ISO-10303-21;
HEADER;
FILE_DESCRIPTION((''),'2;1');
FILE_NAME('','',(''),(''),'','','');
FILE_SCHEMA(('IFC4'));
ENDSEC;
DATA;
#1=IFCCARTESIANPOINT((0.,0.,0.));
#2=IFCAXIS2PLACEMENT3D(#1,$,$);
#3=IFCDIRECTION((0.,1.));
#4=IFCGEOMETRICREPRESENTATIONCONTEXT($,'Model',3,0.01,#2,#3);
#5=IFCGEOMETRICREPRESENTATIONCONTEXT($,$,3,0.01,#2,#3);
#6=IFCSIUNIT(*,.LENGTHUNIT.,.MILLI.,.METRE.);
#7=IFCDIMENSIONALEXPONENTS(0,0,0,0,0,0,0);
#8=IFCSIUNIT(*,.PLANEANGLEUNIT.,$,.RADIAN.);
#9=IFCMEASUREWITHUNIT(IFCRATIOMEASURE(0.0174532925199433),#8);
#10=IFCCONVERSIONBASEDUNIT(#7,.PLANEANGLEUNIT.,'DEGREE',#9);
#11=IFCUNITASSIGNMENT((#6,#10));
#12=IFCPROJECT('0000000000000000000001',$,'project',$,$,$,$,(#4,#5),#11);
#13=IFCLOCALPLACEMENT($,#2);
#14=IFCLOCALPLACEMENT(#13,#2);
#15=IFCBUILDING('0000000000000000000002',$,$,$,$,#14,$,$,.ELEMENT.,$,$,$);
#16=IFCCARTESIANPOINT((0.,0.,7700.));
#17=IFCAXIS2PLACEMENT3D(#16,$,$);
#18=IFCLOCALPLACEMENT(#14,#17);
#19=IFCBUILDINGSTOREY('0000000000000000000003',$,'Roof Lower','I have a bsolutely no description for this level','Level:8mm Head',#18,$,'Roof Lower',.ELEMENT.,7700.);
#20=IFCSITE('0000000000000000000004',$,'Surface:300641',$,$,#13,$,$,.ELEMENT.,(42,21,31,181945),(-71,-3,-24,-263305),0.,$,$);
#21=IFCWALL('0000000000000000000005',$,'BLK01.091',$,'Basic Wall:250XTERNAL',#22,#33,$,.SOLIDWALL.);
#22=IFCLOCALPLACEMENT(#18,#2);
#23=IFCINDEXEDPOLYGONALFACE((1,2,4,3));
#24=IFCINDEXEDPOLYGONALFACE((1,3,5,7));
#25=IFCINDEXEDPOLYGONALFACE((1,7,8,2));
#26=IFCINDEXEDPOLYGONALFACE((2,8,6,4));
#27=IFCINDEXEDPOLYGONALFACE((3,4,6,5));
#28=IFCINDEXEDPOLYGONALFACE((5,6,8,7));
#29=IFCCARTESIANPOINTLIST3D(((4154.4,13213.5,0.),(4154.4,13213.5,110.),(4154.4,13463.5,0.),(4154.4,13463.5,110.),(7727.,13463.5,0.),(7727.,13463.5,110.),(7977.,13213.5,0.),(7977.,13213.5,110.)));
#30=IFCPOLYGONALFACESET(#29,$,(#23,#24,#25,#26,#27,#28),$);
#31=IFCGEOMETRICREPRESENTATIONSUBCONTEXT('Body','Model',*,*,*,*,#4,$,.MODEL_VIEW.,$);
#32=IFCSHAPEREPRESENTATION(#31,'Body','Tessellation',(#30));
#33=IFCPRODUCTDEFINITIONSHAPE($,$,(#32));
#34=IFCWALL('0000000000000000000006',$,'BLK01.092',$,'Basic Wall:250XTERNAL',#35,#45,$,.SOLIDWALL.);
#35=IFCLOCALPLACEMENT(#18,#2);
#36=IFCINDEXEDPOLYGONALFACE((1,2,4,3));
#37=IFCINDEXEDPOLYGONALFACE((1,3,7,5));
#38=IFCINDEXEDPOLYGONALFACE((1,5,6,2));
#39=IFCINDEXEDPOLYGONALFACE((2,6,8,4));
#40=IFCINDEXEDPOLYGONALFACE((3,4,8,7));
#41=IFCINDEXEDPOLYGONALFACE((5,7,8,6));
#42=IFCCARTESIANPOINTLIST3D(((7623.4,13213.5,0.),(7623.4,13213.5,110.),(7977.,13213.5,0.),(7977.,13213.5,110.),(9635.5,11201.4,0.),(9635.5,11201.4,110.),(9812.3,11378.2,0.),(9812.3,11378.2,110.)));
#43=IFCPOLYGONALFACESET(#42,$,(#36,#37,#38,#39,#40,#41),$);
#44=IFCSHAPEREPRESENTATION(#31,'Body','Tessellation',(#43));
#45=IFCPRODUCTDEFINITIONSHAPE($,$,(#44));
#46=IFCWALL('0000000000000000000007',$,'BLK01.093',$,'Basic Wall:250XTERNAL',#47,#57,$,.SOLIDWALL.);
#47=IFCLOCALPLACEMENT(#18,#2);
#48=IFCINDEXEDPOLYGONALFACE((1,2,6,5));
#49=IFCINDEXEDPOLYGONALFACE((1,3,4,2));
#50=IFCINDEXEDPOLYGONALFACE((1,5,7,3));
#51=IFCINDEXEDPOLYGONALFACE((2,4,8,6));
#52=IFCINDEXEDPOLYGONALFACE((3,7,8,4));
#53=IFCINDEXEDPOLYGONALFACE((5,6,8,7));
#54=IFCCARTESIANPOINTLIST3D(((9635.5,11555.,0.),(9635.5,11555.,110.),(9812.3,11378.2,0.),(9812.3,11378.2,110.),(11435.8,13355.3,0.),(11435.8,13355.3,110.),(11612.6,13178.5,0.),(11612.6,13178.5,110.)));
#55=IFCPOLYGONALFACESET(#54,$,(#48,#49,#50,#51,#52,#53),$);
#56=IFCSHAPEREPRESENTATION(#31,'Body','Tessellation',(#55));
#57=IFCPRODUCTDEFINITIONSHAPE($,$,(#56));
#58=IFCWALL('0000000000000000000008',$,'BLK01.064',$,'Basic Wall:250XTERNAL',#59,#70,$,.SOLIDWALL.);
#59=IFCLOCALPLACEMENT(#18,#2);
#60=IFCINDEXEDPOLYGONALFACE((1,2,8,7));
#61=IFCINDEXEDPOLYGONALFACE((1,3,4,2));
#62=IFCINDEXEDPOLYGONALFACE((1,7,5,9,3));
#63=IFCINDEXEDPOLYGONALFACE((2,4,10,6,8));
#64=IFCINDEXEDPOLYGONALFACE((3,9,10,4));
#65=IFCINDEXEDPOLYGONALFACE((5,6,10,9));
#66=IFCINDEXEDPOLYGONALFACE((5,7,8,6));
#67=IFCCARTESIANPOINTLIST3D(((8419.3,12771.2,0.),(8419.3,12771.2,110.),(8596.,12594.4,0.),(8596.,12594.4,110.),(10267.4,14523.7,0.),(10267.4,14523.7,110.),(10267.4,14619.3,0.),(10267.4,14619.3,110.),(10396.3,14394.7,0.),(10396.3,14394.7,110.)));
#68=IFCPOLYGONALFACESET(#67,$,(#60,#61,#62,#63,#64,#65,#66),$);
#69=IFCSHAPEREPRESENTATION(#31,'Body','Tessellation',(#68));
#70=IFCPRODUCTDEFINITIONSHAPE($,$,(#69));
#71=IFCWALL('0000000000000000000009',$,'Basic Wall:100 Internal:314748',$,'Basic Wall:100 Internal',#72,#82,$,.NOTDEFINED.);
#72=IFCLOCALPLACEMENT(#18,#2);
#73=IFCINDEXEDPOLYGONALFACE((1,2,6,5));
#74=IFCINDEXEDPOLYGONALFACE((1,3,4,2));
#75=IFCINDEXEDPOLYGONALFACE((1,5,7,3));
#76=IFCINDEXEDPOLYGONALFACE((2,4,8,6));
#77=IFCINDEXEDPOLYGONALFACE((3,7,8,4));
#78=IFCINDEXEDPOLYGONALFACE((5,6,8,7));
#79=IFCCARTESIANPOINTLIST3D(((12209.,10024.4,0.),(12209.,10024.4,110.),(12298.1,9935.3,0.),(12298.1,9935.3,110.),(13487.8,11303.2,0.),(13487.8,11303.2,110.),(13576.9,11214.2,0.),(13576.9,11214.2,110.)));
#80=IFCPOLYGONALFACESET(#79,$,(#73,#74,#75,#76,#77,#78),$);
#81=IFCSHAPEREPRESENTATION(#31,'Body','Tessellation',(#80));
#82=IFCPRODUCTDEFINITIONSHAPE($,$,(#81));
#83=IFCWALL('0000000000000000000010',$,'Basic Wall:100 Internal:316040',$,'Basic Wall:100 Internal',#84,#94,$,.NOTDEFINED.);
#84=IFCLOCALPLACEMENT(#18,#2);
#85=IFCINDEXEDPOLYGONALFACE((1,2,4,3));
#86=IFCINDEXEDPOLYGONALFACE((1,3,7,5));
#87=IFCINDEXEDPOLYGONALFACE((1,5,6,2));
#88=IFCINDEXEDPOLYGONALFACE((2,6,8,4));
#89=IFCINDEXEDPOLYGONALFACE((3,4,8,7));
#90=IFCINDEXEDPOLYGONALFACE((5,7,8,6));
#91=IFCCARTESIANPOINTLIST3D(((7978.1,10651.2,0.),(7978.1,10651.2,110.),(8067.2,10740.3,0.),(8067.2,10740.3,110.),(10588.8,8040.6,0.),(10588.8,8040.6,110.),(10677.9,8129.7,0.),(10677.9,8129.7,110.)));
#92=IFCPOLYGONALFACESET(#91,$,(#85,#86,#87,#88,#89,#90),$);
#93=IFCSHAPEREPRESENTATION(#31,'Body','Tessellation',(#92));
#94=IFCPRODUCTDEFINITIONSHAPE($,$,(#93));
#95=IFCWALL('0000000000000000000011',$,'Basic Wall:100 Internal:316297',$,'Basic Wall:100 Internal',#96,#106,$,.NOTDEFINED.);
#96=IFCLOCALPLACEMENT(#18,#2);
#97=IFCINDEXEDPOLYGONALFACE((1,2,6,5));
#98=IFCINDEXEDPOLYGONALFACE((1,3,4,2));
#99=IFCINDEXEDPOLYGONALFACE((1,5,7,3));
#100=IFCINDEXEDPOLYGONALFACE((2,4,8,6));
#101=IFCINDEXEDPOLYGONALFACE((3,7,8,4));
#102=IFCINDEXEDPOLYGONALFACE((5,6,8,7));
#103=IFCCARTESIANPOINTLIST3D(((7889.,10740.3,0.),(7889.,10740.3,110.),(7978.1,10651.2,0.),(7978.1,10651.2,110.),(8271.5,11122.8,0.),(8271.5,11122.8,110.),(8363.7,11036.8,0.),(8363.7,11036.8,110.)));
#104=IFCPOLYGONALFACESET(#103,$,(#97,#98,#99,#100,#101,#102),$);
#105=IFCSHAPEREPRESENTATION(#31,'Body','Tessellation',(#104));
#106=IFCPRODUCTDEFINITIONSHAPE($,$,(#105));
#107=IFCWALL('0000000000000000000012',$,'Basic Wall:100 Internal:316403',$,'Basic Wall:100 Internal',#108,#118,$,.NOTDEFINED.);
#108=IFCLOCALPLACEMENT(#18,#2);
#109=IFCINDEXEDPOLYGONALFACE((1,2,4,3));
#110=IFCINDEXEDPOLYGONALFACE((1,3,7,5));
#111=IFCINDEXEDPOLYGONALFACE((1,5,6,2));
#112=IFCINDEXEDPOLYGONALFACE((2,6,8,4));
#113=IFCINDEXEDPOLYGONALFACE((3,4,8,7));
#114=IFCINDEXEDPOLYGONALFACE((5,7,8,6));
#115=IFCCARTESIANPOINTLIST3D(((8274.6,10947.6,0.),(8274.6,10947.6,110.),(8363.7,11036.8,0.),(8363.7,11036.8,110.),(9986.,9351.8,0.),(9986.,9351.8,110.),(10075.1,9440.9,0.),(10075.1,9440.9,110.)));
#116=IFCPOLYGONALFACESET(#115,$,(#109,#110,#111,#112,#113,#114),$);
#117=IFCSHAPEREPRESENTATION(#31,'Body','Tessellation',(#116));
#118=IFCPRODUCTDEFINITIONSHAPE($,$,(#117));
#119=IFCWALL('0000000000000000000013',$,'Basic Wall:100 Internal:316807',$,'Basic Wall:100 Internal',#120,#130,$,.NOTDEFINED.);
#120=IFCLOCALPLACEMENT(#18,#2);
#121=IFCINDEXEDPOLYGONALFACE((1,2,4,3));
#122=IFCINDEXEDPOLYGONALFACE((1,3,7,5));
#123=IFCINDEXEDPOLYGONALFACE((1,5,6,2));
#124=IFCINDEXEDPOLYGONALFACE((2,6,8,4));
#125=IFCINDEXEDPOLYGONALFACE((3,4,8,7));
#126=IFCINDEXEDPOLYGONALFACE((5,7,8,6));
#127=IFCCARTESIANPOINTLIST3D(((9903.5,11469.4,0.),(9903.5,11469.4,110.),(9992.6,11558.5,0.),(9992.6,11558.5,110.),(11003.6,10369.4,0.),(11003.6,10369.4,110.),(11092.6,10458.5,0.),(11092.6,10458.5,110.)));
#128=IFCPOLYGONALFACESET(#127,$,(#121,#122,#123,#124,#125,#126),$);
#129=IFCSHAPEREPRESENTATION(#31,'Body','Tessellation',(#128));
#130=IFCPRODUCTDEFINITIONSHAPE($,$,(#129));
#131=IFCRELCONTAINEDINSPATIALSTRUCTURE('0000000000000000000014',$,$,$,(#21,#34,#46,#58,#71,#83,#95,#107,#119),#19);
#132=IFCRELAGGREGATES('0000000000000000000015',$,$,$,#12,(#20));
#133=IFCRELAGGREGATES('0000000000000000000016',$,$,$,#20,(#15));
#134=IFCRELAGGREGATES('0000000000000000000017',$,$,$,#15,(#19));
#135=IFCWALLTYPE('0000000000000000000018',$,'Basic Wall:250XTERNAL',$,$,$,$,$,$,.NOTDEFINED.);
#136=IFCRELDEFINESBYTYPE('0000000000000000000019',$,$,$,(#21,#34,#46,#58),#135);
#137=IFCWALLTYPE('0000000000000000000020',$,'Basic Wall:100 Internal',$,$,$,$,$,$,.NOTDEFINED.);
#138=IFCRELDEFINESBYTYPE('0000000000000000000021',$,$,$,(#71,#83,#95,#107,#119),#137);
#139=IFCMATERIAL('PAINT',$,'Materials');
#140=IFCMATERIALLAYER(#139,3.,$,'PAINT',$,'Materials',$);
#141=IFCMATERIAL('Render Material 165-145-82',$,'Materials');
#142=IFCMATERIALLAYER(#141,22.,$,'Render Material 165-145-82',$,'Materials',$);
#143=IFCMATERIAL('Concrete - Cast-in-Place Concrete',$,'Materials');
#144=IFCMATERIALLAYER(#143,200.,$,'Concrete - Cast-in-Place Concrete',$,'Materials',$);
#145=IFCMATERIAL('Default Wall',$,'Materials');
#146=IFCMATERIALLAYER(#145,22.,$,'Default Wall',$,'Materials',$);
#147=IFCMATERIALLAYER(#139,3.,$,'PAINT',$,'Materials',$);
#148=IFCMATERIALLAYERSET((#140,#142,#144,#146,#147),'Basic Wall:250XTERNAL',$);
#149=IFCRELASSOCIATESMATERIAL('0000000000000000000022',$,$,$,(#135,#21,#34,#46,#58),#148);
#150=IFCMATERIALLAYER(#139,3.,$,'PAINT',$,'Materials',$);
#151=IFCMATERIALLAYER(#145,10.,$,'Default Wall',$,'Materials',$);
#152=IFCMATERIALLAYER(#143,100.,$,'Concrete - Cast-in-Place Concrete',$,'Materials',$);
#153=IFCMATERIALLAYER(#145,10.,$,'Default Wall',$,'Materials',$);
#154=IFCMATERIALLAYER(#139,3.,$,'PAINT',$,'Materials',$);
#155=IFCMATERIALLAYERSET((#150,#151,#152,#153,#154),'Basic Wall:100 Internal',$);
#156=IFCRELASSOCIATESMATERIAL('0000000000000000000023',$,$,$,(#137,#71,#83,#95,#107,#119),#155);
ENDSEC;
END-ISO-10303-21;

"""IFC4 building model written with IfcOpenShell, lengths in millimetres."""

from ifc_helpers import new_model, entity, si_unit, converted_unit, direction, frame, frame_2d, origin, place, context, subcontext, project, spatial, polyline, rectangle, outline, extrude, clip, halfspace, bounded_halfspace, material, layer, layer_set, layer_usage, type_object, element, save


model = new_model("IFC4")

# Units and contexts
model_context = context("Model", 3, precision=0.01, world=origin(), true_north=direction((0.0, 1.0)))
context_of_model = context(None, 3, precision=0.01, world=origin(), true_north=direction((0.0, 1.0)))
body_context = subcontext(model_context, "Body", "Model", "MODEL_VIEW")
ifc_project = project(units=[si_unit("LENGTHUNIT", "METRE", prefix="MILLI"), converted_unit("PLANEANGLEUNIT", "DEGREE", entity("IfcRatioMeasure", 0.0174532925199433), si_unit("PLANEANGLEUNIT", "RADIAN"), dimensions=[0, 0, 0, 0, 0, 0, 0])], contexts=[model_context, context_of_model])

# Site, building, storey
site_placement = place(None, origin())
site = spatial("IfcSite", under=ifc_project, at=site_placement, Name="Surface:300641", CompositionType="ELEMENT", RefLatitude=(42, 21, 31, 181945), RefLongitude=(-71, -3, -24, -263305), RefElevation=0.0)
building_placement = place(site_placement, origin())
building = spatial("IfcBuilding", under=site, at=building_placement, CompositionType="ELEMENT")
storey_placement = place(building_placement, frame((0.0, 0.0, 7700.0)))
storey = spatial("IfcBuildingStorey", under=building, at=storey_placement, Name="Roof Lower", Description="I have a bsolutely no description for this level", ObjectType="Level:8mm Head", LongName="Roof Lower", CompositionType="ELEMENT", Elevation=7700.0)

# Shared definitions
ifc_material_1 = material(Name="Concrete - Cast-in-Place Concrete", Category="Materials")

# Walls
ifc_material_2 = material(Name="PAINT", Category="Materials")
ifc_layer_1 = layer(ifc_material_2, 3.0, Name="PAINT", Category="Materials")
ifc_material_3 = material(Name="Render Material 165-145-82", Category="Materials")
ifc_layer_2 = layer(ifc_material_3, 22.0, Name="Render Material 165-145-82", Category="Materials")
ifc_layer_3 = layer(ifc_material_1, 200.0, Name="Concrete - Cast-in-Place Concrete", Category="Materials")
ifc_material_4 = material(Name="Default Wall", Category="Materials")
ifc_layer_4 = layer(ifc_material_4, 22.0, Name="Default Wall", Category="Materials")
ifc_layer_5 = layer(ifc_material_2, 3.0, Name="PAINT", Category="Materials")
ifc_layer_set_1 = layer_set([ifc_layer_1, ifc_layer_2, ifc_layer_3, ifc_layer_4, ifc_layer_5], Name="Basic Wall:250XTERNAL")
ifc_layer_usage_1 = layer_usage(ifc_layer_set_1, "AXIS2", "NEGATIVE", 125.0)
wall_type_1 = type_object("IfcWallType", Name="Basic Wall:250XTERNAL", PredefinedType="NOTDEFINED", material=ifc_layer_set_1)
wall_1_placement = place(storey_placement, frame((4154.4, 13338.5, 0.0)))
element("IfcWall", 1, at=wall_1_placement, inside=storey, type_object=wall_type_1, material=ifc_layer_usage_1, Name="BLK01.091", ObjectType="Basic Wall:250XTERNAL", PredefinedType="SOLIDWALL", context=body_context, shape_type="Clipping", body=[
    clip(clip(extrude(outline(polyline([(0.0, -125.0), (3469.0, -125.0), (3822.5, -125.0), (3572.5, 125.0), (0.0, 125.0), (0.0, -125.0)])), origin(), (0.0, 0.0, 1.0), 110.0), bounded_halfspace(frame((0.0, -125.0, 110.0), z_axis=(0.0, 0.0, -1.0), x_axis=(1.0, 0.0, 0.0)), True, frame((0.0, -125.0, 110.0)), polyline([(0.0, 0.0), (3469.0, 0.0), (3822.5, 0.0), (3572.5, 250.0), (0.0, 250.0), (0.0, 0.0)]))), halfspace(frame((0.0, 0.0, -3500.0)), True)),
])
ifc_layer_usage_2 = layer_usage(ifc_layer_set_1, "AXIS2", "NEGATIVE", 125.0)
wall_2_placement = place(storey_placement, frame((7711.8, 13301.9, 0.0), z_axis=(0.0, 0.0, 1.0), x_axis=(0.707107, -0.707107, 0.0)))
element("IfcWall", 2, at=wall_2_placement, inside=storey, type_object=wall_type_1, material=ifc_layer_usage_2, Name="BLK01.092", ObjectType="Basic Wall:250XTERNAL", PredefinedType="SOLIDWALL", context=body_context, shape_type="Clipping", body=[
    clip(clip(extrude(outline(polyline([(2845.5, -125.0), (2845.5, 0.0), (2845.5, 125.0), (2595.5, 125.0), (1125.5, 125.0), (875.5, 125.0), (250.0, 125.0), (0.0, -125.0), (2845.5, -125.0)])), origin(), (0.0, 0.0, 1.0), 110.0), bounded_halfspace(frame((0.0, -125.0, 110.0), z_axis=(0.0, 0.0, -1.0), x_axis=(0.707107, 0.707107, 0.0)), True, frame((0.0, -125.0, 110.0)), polyline([(0.0, 0.0), (2845.5, 0.0), (2845.5, 125.0), (2845.5, 250.0), (2595.5, 250.0), (1125.5, 250.0), (875.5, 250.0), (250.0, 250.0), (0.0, 0.0)]))), halfspace(frame((0.0, 0.0, -3500.0)), True)),
])
ifc_layer_usage_3 = layer_usage(ifc_layer_set_1, "AXIS2", "NEGATIVE", 125.0)
wall_3_placement = place(storey_placement, frame((9723.9, 11466.6, 0.0), z_axis=(0.0, 0.0, 1.0), x_axis=(0.707107, 0.707107, 0.0)))
element("IfcWall", 3, at=wall_3_placement, inside=storey, type_object=wall_type_1, material=ifc_layer_usage_3, Name="BLK01.093", ObjectType="Basic Wall:250XTERNAL", PredefinedType="SOLIDWALL", context=body_context, shape_type="Clipping", body=[
    clip(clip(extrude(rectangle(XDim=2546.0, YDim=250.0, at=frame_2d((1273.0, 0.0), x_axis=(-1.0, 0.0))), origin(), (0.0, 0.0, 1.0), 110.0), bounded_halfspace(frame((0.0, -125.0, 110.0), z_axis=(0.0, 0.0, -1.0), x_axis=(0.707107, -0.707107, 0.0)), True, frame((0.0, -125.0, 110.0)), polyline([(0.0, 0.0), (129.0, 0.0), (255.0, 0.0), (2546.0, 0.0), (2546.0, 250.0), (0.0, 250.0), (0.0, 0.0)]))), halfspace(frame((0.0, 0.0, -3500.0)), True)),
])
ifc_layer_usage_4 = layer_usage(ifc_layer_set_1, "AXIS2", "POSITIVE", -125.0)
wall_4_placement = place(storey_placement, frame((8507.6, 12682.8, 0.0), z_axis=(0.0, 0.0, 1.0), x_axis=(0.707107, 0.707107, 0.0)))
element("IfcWall", 4, at=wall_4_placement, inside=storey, type_object=wall_type_1, material=ifc_layer_usage_4, Name="BLK01.064", ObjectType="Basic Wall:250XTERNAL", PredefinedType="SOLIDWALL", context=body_context, shape_type="Clipping", body=[
    clip(clip(extrude(outline(polyline([(2546.0, -125.0), (2546.0, 57.4), (2613.6, 125.0), (0.0, 125.0), (0.0, -125.0), (2546.0, -125.0)])), origin(), (0.0, 0.0, 1.0), 110.0), bounded_halfspace(frame((0.0, -125.0, 110.0), z_axis=(0.0, 0.0, -1.0), x_axis=(0.707107, -0.707107, 0.0)), True, frame((0.0, -125.0, 110.0)), polyline([(0.0, 0.0), (2546.0, 0.0), (2546.0, 182.4), (2613.6, 250.0), (0.0, 250.0), (0.0, 0.0)]))), halfspace(frame((0.0, 0.0, -3500.0)), True)),
])
ifc_layer_6 = layer(ifc_material_2, 3.0, Name="PAINT", Category="Materials")
ifc_layer_7 = layer(ifc_material_4, 10.0, Name="Default Wall", Category="Materials")
ifc_layer_8 = layer(ifc_material_1, 100.0, Name="Concrete - Cast-in-Place Concrete", Category="Materials")
ifc_layer_9 = layer(ifc_material_4, 10.0, Name="Default Wall", Category="Materials")
ifc_layer_10 = layer(ifc_material_2, 3.0, Name="PAINT", Category="Materials")
ifc_layer_set_2 = layer_set([ifc_layer_6, ifc_layer_7, ifc_layer_8, ifc_layer_9, ifc_layer_10], Name="Basic Wall:100 Internal")
ifc_layer_usage_5 = layer_usage(ifc_layer_set_2, "AXIS2", "NEGATIVE", 63.0)
wall_type_2 = type_object("IfcWallType", Name="Basic Wall:100 Internal", PredefinedType="NOTDEFINED", material=ifc_layer_set_2)
wall_5_placement = place(storey_placement, frame((13532.4, 11258.7, 0.0), z_axis=(0.0, 0.0, 1.0), x_axis=(-0.707107, -0.707107, 0.0)))
element("IfcWall", 5, at=wall_5_placement, inside=storey, type_object=wall_type_2, material=ifc_layer_usage_5, Name="Basic Wall:100 Internal:314748", ObjectType="Basic Wall:100 Internal", PredefinedType="NOTDEFINED", context=body_context, shape_type="Clipping", body=[
    clip(clip(extrude(rectangle(XDim=1808.6, YDim=126.0, at=frame_2d((904.3, 0.0), x_axis=(-1.0, 0.0))), origin(), (0.0, 0.0, 1.0), 110.0), bounded_halfspace(frame((0.0, -63.0, 110.0), z_axis=(0.0, 0.0, -1.0), x_axis=(-0.707107, 0.707107, 0.0)), True, frame((0.0, -63.0, 110.0)), polyline([(0.0, 0.0), (1808.6, 0.0), (1808.6, 126.0), (0.0, 126.0), (0.0, 0.0)]))), halfspace(frame((0.0, 0.0, -3500.0)), True)),
])
ifc_layer_usage_6 = layer_usage(ifc_layer_set_2, "AXIS2", "POSITIVE", -63.0)
wall_6_placement = place(storey_placement, frame((8022.7, 10695.7, 0.0), z_axis=(0.0, 0.0, 1.0), x_axis=(0.707107, -0.707107, 0.0)))
element("IfcWall", 6, at=wall_6_placement, inside=storey, type_object=wall_type_2, material=ifc_layer_usage_6, Name="Basic Wall:100 Internal:316040", ObjectType="Basic Wall:100 Internal", PredefinedType="NOTDEFINED", context=body_context, shape_type="Clipping", body=[
    clip(clip(extrude(rectangle(XDim=3692.0, YDim=126.0, at=frame_2d((1846.0, 0.0), x_axis=(-1.0, 0.0))), origin(), (0.0, 0.0, 1.0), 110.0), bounded_halfspace(frame((0.0, -63.0, 110.0), z_axis=(0.0, 0.0, -1.0), x_axis=(0.707107, 0.707107, 0.0)), True, frame((0.0, -63.0, 110.0)), polyline([(0.0, 0.0), (3692.0, 0.0), (3692.0, 126.0), (2338.6, 126.0), (2212.6, 126.0), (0.0, 126.0), (0.0, 0.0)]))), halfspace(frame((0.0, 0.0, -3500.0)), True)),
])
ifc_layer_usage_7 = layer_usage(ifc_layer_set_2, "AXIS2", "NEGATIVE", 63.0)
wall_7_placement = place(storey_placement, frame((7933.6, 10695.7, 0.0), z_axis=(0.0, 0.0, 1.0), x_axis=(0.707107, 0.707107, 0.0)))
element("IfcWall", 7, at=wall_7_placement, inside=storey, type_object=wall_type_2, material=ifc_layer_usage_7, Name="Basic Wall:100 Internal:316297", ObjectType="Basic Wall:100 Internal", PredefinedType="NOTDEFINED", context=body_context, shape_type="Clipping", body=[
    clip(clip(extrude(outline(polyline([(545.3, -63.0), (540.9, 63.0), (0.0, 63.0), (0.0, -63.0), (126.0, -63.0), (419.2, -63.0), (545.3, -63.0)])), origin(), (0.0, 0.0, 1.0), 110.0), bounded_halfspace(frame((0.0, -63.0, 110.0), z_axis=(0.0, 0.0, -1.0), x_axis=(0.707107, -0.707107, 0.0)), True, frame((0.0, -63.0, 110.0)), polyline([(0.0, 0.0), (126.0, 0.0), (419.2, 0.0), (545.3, 0.0), (540.9, 126.0), (0.0, 126.0), (0.0, 0.0)]))), halfspace(frame((0.0, 0.0, -3500.0)), True)),
])
ifc_layer_usage_8 = layer_usage(ifc_layer_set_2, "AXIS2", "NEGATIVE", 63.0)
wall_8_placement = place(storey_placement, frame((8317.6, 10993.7, 0.0), z_axis=(0.0, 0.0, 1.0), x_axis=(0.731354, -0.681998, 0.0)))
element("IfcWall", 8, at=wall_8_placement, inside=storey, type_object=wall_type_2, material=ifc_layer_usage_8, Name="Basic Wall:100 Internal:316403", ObjectType="Basic Wall:100 Internal", PredefinedType="NOTDEFINED", context=body_context, shape_type="Clipping", body=[
    clip(clip(extrude(outline(polyline([(2340.0, -63.0), (2344.4, 63.0), (2218.3, 63.0), (4.4, 63.0), (0.0, -63.0), (2213.9, -63.0), (2340.0, -63.0)])), origin(), (0.0, 0.0, 1.0), 110.0), bounded_halfspace(frame((0.0, -63.0, 110.0), z_axis=(0.0, 0.0, -1.0), x_axis=(0.731354, 0.681998, 0.0)), True, frame((0.0, -63.0, 110.0)), polyline([(0.0, 0.0), (2213.9, 0.0), (2340.0, 0.0), (2344.4, 126.0), (2218.3, 126.0), (4.4, 126.0), (0.0, 0.0)]))), halfspace(frame((0.0, 0.0, -3500.0)), True)),
])
ifc_layer_usage_9 = layer_usage(ifc_layer_set_2, "AXIS2", "NEGATIVE", 63.0)
wall_9_placement = place(storey_placement, frame((9948.0, 11514.0, 0.0), z_axis=(0.0, 0.0, 1.0), x_axis=(0.707107, -0.707107, 0.0)))
element("IfcWall", 9, at=wall_9_placement, inside=storey, type_object=wall_type_2, material=ifc_layer_usage_9, Name="Basic Wall:100 Internal:316807", ObjectType="Basic Wall:100 Internal", PredefinedType="NOTDEFINED", context=body_context, shape_type="Clipping", body=[
    clip(clip(extrude(rectangle(XDim=1555.7, YDim=126.0, at=frame_2d((777.9, 0.0), x_axis=(-1.0, 0.0))), origin(), (0.0, 0.0, 1.0), 110.0), bounded_halfspace(frame((0.0, -63.0, 110.0), z_axis=(0.0, 0.0, -1.0), x_axis=(0.707107, 0.707107, 0.0)), True, frame((0.0, -63.0, 110.0)), polyline([(0.0, 0.0), (1429.7, 0.0), (1555.7, 0.0), (1555.7, 126.0), (0.0, 126.0), (0.0, 0.0)]))), halfspace(frame((0.0, 0.0, -3500.0)), True)),
])

save(model, "model.ifc")
